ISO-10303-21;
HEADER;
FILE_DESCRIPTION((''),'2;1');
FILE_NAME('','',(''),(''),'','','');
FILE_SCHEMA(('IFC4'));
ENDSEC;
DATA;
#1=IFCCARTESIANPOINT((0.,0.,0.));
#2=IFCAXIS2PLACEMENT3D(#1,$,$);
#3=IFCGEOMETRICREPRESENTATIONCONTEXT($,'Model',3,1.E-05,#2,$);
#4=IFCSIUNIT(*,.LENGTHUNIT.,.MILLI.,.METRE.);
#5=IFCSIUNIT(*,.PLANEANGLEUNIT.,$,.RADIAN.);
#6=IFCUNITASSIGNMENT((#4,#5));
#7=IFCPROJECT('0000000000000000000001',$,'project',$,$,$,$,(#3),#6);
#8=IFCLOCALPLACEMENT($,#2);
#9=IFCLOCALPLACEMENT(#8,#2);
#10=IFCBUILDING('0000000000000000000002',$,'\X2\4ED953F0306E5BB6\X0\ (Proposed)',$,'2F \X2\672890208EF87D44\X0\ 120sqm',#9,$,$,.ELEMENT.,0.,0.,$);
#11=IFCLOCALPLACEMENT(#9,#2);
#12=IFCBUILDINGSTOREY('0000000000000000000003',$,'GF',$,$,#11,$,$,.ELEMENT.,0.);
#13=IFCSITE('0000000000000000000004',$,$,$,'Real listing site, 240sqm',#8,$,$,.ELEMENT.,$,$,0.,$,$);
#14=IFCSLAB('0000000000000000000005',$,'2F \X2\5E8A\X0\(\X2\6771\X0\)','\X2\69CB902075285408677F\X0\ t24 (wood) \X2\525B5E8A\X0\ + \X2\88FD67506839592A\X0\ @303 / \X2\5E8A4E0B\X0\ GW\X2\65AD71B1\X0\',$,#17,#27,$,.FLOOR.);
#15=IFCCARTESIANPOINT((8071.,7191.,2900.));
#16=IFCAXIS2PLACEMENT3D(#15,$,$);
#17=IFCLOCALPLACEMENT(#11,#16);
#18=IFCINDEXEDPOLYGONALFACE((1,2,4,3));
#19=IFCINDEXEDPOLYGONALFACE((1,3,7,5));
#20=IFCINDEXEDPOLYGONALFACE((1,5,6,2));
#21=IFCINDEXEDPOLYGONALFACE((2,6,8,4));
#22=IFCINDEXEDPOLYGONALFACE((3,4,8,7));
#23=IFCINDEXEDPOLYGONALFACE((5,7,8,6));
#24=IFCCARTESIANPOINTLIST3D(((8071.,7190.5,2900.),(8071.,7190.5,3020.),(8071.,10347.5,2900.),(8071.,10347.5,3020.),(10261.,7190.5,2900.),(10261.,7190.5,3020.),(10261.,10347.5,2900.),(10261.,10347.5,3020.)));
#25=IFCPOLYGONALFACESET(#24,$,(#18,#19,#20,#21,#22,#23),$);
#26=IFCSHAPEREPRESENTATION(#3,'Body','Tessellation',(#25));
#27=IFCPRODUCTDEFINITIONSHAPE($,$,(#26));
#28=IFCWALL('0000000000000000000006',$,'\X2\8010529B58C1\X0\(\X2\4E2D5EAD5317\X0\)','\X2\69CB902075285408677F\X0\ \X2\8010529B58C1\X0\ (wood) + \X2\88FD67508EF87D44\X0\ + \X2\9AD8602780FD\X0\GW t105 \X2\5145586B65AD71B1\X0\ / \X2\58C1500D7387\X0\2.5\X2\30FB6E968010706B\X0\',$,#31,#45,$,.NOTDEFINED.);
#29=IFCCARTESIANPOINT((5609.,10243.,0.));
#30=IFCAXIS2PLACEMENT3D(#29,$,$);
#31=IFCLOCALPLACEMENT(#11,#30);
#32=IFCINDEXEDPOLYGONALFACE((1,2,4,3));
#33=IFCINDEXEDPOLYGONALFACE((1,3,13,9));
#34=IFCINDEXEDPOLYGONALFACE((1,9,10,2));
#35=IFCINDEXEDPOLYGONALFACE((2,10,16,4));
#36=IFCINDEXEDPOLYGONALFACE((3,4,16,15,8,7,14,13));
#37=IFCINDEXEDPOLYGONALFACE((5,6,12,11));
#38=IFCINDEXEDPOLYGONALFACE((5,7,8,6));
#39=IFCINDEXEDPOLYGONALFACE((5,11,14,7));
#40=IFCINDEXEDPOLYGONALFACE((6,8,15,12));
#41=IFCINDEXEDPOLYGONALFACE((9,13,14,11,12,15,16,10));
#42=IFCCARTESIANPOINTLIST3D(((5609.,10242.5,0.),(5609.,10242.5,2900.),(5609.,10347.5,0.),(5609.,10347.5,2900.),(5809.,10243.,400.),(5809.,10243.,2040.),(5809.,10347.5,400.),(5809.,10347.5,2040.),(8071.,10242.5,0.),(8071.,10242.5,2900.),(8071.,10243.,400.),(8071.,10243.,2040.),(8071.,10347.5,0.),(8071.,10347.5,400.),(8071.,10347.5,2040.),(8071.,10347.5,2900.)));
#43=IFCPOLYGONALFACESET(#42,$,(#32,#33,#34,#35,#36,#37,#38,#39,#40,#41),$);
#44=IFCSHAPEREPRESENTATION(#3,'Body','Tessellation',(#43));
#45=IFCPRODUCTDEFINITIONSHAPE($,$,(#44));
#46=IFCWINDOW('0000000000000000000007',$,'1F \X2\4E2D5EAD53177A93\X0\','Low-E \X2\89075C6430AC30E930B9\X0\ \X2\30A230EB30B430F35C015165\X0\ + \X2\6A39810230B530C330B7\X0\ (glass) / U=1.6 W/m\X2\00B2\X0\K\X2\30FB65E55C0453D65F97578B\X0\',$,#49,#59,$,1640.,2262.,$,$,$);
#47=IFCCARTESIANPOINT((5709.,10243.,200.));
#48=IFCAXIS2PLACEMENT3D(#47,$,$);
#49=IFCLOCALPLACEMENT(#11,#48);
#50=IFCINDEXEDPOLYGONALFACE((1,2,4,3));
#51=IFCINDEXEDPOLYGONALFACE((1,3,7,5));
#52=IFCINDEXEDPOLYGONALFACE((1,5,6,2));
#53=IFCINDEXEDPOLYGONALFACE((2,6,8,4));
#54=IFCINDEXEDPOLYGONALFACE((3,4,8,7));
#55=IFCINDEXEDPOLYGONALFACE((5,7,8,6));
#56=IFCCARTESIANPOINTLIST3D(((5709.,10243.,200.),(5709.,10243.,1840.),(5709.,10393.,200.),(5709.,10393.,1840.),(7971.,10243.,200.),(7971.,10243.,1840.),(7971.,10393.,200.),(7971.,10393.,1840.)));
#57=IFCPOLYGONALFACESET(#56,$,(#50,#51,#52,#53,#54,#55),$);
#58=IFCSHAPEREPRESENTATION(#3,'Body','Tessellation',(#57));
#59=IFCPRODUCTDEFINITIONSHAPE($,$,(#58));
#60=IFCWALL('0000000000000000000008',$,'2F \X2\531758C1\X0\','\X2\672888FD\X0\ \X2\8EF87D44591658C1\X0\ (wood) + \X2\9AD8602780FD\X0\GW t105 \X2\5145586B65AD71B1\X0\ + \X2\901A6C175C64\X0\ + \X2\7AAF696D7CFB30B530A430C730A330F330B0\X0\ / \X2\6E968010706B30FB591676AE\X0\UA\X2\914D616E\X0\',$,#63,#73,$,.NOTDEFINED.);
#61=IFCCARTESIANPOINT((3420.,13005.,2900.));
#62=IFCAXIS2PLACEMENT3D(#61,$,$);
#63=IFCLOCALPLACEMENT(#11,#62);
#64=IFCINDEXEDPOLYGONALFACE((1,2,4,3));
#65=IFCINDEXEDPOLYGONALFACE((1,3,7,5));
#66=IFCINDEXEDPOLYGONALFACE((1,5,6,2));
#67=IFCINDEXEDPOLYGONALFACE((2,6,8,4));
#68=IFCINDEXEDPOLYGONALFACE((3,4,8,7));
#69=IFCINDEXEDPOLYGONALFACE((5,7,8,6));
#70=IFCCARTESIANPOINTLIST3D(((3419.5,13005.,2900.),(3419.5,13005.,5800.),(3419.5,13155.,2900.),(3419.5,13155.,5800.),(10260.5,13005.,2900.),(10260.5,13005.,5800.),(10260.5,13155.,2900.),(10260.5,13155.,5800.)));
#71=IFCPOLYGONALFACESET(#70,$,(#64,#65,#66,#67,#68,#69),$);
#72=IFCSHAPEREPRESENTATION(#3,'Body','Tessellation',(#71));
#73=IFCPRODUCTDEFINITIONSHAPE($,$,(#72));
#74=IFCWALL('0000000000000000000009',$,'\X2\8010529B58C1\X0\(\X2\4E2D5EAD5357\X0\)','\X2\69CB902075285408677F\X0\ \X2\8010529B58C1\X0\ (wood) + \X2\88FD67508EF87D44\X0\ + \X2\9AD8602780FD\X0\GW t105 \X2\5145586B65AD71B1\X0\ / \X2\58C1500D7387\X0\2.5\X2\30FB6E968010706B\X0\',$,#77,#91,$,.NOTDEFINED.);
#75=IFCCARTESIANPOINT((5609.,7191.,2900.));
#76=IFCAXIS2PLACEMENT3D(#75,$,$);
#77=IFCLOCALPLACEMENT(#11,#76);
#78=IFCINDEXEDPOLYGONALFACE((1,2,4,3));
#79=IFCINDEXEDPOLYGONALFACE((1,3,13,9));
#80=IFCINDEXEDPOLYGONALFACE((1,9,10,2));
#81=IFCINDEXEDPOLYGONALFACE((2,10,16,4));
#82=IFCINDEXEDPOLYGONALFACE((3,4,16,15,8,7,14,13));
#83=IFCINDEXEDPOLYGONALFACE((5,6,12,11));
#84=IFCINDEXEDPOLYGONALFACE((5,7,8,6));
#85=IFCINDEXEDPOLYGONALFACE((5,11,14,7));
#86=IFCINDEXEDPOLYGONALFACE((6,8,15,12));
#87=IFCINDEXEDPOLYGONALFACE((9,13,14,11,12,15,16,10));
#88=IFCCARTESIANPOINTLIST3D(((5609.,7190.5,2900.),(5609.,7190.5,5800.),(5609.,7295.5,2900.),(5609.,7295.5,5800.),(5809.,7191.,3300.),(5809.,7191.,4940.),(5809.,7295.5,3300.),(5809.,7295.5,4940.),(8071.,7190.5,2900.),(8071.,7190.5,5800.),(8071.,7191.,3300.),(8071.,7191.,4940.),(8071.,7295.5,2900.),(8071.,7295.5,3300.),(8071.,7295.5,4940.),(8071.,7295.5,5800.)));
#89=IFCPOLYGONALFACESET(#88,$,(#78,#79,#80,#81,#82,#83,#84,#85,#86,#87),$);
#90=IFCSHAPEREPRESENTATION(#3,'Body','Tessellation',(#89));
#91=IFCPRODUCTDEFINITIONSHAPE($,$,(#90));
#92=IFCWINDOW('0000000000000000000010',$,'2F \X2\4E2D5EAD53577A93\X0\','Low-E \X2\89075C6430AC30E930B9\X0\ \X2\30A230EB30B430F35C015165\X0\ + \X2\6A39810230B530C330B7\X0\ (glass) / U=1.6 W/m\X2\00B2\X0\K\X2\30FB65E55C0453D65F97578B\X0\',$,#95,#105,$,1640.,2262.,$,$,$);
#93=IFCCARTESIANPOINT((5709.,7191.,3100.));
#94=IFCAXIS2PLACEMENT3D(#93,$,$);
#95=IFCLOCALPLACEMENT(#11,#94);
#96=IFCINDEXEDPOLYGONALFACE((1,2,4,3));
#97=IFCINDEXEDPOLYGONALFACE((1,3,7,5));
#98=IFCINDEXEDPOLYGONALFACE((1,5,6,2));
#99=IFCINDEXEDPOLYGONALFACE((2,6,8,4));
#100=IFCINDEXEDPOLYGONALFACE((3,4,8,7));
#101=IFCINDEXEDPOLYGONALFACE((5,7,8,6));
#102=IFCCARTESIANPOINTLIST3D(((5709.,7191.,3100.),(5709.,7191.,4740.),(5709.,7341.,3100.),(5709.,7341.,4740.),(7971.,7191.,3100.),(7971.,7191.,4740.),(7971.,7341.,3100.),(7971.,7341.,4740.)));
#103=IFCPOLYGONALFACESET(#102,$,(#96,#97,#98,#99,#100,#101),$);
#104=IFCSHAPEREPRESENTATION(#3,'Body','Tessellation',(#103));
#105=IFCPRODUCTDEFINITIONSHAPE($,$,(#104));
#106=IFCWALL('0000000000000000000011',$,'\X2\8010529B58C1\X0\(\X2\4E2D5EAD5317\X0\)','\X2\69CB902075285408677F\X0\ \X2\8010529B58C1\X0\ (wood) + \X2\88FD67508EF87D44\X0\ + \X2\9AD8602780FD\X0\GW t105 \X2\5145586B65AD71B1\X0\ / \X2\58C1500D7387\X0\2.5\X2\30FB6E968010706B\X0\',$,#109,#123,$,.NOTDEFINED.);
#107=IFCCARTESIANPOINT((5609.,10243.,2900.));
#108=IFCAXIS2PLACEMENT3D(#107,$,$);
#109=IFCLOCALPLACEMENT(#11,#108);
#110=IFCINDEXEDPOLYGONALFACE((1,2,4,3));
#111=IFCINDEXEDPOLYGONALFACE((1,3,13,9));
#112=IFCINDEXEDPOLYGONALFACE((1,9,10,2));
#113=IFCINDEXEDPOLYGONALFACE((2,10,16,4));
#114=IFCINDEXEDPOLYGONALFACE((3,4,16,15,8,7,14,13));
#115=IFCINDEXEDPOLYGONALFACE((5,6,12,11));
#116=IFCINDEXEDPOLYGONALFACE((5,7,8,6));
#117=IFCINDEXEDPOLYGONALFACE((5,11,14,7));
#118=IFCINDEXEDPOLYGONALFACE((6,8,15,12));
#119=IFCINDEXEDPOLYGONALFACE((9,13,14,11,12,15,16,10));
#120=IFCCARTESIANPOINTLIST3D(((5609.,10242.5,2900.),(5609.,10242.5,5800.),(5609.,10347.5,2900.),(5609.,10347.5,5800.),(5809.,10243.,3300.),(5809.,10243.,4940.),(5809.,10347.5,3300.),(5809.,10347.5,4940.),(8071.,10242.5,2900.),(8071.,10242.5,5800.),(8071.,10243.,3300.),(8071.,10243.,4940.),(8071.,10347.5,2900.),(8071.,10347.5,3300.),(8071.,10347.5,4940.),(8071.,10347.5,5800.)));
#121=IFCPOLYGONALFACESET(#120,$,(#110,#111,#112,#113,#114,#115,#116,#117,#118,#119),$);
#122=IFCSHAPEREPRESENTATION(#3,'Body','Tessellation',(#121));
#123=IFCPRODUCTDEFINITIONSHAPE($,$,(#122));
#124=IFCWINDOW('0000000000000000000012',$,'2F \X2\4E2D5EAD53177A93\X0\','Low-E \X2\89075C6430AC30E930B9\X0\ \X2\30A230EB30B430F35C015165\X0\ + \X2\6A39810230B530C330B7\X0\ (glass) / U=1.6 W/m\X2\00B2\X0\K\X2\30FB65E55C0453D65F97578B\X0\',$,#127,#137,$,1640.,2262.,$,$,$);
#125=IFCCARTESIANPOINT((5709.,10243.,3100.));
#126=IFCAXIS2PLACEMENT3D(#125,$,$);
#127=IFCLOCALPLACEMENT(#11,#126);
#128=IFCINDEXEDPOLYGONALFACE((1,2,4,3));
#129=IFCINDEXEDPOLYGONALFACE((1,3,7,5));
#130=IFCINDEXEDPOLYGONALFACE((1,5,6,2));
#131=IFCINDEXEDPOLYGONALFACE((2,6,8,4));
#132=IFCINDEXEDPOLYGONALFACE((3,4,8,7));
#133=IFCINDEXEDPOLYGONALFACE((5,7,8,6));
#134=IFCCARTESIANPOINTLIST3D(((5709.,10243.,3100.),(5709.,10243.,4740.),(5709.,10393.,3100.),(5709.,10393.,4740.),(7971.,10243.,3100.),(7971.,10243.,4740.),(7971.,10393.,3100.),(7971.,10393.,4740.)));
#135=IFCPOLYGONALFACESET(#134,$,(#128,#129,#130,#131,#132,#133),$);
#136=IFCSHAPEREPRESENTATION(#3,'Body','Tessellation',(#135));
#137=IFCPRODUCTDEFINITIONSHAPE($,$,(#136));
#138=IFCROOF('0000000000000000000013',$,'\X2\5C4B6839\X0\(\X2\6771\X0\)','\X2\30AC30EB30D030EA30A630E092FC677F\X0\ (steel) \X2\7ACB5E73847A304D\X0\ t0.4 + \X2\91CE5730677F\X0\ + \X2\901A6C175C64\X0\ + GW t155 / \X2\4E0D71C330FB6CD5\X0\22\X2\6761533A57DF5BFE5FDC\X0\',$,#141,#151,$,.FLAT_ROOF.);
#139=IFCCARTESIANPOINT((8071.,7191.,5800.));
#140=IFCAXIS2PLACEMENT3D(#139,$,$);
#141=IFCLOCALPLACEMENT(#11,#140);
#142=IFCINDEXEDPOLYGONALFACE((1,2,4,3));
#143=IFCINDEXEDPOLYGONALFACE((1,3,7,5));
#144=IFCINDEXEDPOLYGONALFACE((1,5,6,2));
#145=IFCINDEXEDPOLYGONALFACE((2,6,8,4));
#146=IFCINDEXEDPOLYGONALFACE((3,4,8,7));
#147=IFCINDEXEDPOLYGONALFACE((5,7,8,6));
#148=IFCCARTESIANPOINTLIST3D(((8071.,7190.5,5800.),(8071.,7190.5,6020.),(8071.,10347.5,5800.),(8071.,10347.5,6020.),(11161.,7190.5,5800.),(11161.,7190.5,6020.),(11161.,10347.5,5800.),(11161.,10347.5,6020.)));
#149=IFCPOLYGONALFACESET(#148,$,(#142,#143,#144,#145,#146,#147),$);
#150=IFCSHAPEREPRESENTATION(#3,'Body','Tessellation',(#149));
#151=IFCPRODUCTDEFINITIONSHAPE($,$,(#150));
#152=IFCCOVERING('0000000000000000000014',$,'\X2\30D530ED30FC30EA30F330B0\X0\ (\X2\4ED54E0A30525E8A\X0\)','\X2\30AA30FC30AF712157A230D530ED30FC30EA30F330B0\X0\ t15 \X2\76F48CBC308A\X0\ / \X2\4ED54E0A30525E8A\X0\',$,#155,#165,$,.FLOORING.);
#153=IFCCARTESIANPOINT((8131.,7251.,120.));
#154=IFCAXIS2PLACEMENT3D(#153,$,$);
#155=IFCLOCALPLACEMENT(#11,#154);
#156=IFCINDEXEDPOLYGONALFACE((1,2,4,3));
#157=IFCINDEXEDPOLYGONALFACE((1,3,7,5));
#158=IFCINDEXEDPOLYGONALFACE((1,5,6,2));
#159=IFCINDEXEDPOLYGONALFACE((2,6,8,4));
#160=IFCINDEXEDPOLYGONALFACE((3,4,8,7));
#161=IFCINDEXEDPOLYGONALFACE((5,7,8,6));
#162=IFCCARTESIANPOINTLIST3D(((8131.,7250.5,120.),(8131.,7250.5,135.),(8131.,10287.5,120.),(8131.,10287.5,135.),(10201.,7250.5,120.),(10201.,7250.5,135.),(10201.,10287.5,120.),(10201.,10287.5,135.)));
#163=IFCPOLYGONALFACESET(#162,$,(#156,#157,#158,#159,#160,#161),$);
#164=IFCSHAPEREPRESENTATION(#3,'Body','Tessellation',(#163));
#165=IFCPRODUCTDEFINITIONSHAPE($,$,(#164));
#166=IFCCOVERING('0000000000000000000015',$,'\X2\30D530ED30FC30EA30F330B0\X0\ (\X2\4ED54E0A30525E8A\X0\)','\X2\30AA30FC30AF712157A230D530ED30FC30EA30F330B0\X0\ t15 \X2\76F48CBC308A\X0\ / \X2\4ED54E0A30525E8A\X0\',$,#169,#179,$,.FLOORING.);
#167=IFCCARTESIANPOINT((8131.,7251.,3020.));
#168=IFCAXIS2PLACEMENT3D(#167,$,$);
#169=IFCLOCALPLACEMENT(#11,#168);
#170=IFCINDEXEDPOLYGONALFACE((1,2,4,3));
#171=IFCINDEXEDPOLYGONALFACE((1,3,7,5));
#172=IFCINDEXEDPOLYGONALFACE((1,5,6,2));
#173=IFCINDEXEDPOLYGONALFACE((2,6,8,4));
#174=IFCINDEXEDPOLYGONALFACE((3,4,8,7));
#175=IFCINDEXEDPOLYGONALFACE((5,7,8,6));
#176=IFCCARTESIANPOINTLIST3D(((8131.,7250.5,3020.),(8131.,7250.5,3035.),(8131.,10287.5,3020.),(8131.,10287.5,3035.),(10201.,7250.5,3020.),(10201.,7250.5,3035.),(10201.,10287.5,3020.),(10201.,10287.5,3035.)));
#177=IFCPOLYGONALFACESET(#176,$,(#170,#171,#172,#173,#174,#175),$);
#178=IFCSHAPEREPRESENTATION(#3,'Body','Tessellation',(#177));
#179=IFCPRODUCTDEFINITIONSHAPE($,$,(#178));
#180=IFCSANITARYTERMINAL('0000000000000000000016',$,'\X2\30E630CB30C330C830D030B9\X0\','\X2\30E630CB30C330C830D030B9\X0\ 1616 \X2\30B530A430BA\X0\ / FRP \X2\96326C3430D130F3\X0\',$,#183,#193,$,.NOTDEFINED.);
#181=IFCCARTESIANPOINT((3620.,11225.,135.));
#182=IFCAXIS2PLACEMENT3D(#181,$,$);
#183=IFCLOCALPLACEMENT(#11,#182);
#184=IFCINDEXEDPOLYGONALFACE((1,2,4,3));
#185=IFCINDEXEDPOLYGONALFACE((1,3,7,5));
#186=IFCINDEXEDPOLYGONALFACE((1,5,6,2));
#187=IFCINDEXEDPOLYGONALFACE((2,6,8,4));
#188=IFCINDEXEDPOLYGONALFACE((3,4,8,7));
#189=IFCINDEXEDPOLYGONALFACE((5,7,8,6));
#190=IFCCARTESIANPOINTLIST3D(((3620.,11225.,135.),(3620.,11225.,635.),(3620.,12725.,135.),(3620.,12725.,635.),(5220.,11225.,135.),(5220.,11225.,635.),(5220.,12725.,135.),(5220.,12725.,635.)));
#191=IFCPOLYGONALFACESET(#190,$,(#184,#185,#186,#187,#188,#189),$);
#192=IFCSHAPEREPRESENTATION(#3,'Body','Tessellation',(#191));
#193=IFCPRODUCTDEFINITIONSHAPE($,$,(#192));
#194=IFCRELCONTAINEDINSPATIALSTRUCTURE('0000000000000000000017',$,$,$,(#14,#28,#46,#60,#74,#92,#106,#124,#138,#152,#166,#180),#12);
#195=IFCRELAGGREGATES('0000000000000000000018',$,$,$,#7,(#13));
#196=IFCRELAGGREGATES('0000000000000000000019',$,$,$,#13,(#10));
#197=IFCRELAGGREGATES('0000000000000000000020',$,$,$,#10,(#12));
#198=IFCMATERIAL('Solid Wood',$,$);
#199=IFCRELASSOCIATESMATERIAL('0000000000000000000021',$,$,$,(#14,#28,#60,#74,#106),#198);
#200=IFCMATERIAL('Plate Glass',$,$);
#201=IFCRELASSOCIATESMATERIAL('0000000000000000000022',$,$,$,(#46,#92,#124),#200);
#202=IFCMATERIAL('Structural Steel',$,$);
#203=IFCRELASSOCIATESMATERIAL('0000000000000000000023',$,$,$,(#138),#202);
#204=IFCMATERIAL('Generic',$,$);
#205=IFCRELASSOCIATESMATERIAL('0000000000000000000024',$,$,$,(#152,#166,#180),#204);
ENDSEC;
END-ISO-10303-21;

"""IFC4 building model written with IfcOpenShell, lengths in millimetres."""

from ifc_helpers import new_model, si_unit, frame, frame_2d, origin, place, context, project, spatial, rectangle, extrude, material, element, fill, save


model = new_model("IFC4")

# Units and contexts
model_context = context("Model", 3, precision=1e-05, world=origin())
ifc_project = project(units=[si_unit("LENGTHUNIT", "METRE", prefix="MILLI"), si_unit("PLANEANGLEUNIT", "RADIAN")], contexts=[model_context])

# Site, building, storey
site_placement = place(None, origin())
site = spatial("IfcSite", under=ifc_project, at=site_placement, ObjectType="Real listing site, 240sqm", CompositionType="ELEMENT", RefElevation=0.0)
building_placement = place(site_placement, origin())
building = spatial("IfcBuilding", under=site, at=building_placement, Name="仙台の家 (Proposed)", ObjectType="2F 木造軸組 120sqm", CompositionType="ELEMENT", ElevationOfRefHeight=0.0, ElevationOfTerrain=0.0)
storey_placement = place(building_placement, origin())
storey = spatial("IfcBuildingStorey", under=building, at=storey_placement, Name="GF", CompositionType="ELEMENT", Elevation=0.0)

# Slab
ifc_material_1 = material(Name="Solid Wood")
slab_1_placement = place(storey_placement, frame((8071.0, 7191.0, 2900.0)))
element("IfcSlab", 1, at=slab_1_placement, inside=storey, material=ifc_material_1, Name="2F 床(東)", Description="構造用合板 t24 (wood) 剛床 + 製材根太 @303 / 床下 GW断熱", PredefinedType="FLOOR", context=model_context, shape_type="SweptSolid", body=[
    extrude(rectangle(XDim=2190.0, YDim=3157.0, at=frame_2d((1095.0, 1578.0))), frame((8071.0, 7191.0, 2900.0)), (0.0, 0.0, 1.0), 120.0),
])

# Wall, opening, window
wall_1_placement = place(storey_placement, frame((5609.0, 10243.0, 0.0)))
wall_1 = element("IfcWall", 2, at=wall_1_placement, inside=storey, material=ifc_material_1, Name="耐力壁(中庭北)", Description="構造用合板 耐力壁 (wood) + 製材軸組 + 高性能GW t105 充填断熱 / 壁倍率2.5・準耐火", PredefinedType="NOTDEFINED", context=model_context, shape_type="SweptSolid", body=[
    extrude(rectangle(XDim=2462.0, YDim=105.0, at=frame_2d((1231.0, 52.0))), frame((5609.0, 10243.0, 0.0)), (0.0, 0.0, 1.0), 2900.0),
])
opening_1_placement = place(storey_placement, frame((5709.0, 10243.0, 200.0)))
opening_1 = element("IfcOpeningElement", 3, at=opening_1_placement, cuts=wall_1, PredefinedType="NOTDEFINED", context=model_context, shape_type="SweptSolid", body=[
    extrude(rectangle(XDim=2262.0, YDim=150.0, at=frame_2d((1131.0, 75.0))), frame((5709.0, 10243.0, 200.0)), (0.0, 0.0, 1.0), 1640.0),
])
ifc_material_2 = material(Name="Plate Glass")
window_1_placement = place(storey_placement, frame((5709.0, 10243.0, 200.0)))
window_1 = element("IfcWindow", 4, at=window_1_placement, inside=storey, material=ifc_material_2, Name="1F 中庭北窓", Description="Low-E 複層ガラス アルゴン封入 + 樹脂サッシ (glass) / U=1.6 W/m²K・日射取得型", OverallHeight=1640.0, OverallWidth=2262.0, context=model_context, shape_type="SweptSolid", body=[
    extrude(rectangle(XDim=2262.0, YDim=150.0, at=frame_2d((1131.0, 75.0))), frame((5709.0, 10243.0, 200.0)), (0.0, 0.0, 1.0), 1640.0),
])
fill(opening_1, window_1)

# Wall
wall_2_placement = place(storey_placement, frame((3420.0, 13005.0, 2900.0)))
element("IfcWall", 5, at=wall_2_placement, inside=storey, material=ifc_material_1, Name="2F 北壁", Description="木製 軸組外壁 (wood) + 高性能GW t105 充填断熱 + 通気層 + 窯業系サイディング / 準耐火・外皮UA配慮", PredefinedType="NOTDEFINED", context=model_context, shape_type="SweptSolid", body=[
    extrude(rectangle(XDim=6841.0, YDim=150.0, at=frame_2d((3420.0, 75.0))), frame((3420.0, 13005.0, 2900.0)), (0.0, 0.0, 1.0), 2900.0),
])

# Walls, openings, windows
wall_3_placement = place(storey_placement, frame((5609.0, 7191.0, 2900.0)))
wall_3 = element("IfcWall", 6, at=wall_3_placement, inside=storey, material=ifc_material_1, Name="耐力壁(中庭南)", Description="構造用合板 耐力壁 (wood) + 製材軸組 + 高性能GW t105 充填断熱 / 壁倍率2.5・準耐火", PredefinedType="NOTDEFINED", context=model_context, shape_type="SweptSolid", body=[
    extrude(rectangle(XDim=2462.0, YDim=105.0, at=frame_2d((1231.0, 52.0))), frame((5609.0, 7191.0, 2900.0)), (0.0, 0.0, 1.0), 2900.0),
])
opening_2_placement = place(storey_placement, frame((5709.0, 7191.0, 3100.0)))
opening_2 = element("IfcOpeningElement", 7, at=opening_2_placement, cuts=wall_3, PredefinedType="NOTDEFINED", context=model_context, shape_type="SweptSolid", body=[
    extrude(rectangle(XDim=2262.0, YDim=150.0, at=frame_2d((1131.0, 75.0))), frame((5709.0, 7191.0, 3100.0)), (0.0, 0.0, 1.0), 1640.0),
])
window_2_placement = place(storey_placement, frame((5709.0, 7191.0, 3100.0)))
window_2 = element("IfcWindow", 8, at=window_2_placement, inside=storey, material=ifc_material_2, Name="2F 中庭南窓", Description="Low-E 複層ガラス アルゴン封入 + 樹脂サッシ (glass) / U=1.6 W/m²K・日射取得型", OverallHeight=1640.0, OverallWidth=2262.0, context=model_context, shape_type="SweptSolid", body=[
    extrude(rectangle(XDim=2262.0, YDim=150.0, at=frame_2d((1131.0, 75.0))), frame((5709.0, 7191.0, 3100.0)), (0.0, 0.0, 1.0), 1640.0),
])
fill(opening_2, window_2)
wall_4_placement = place(storey_placement, frame((5609.0, 10243.0, 2900.0)))
wall_4 = element("IfcWall", 9, at=wall_4_placement, inside=storey, material=ifc_material_1, Name="耐力壁(中庭北)", Description="構造用合板 耐力壁 (wood) + 製材軸組 + 高性能GW t105 充填断熱 / 壁倍率2.5・準耐火", PredefinedType="NOTDEFINED", context=model_context, shape_type="SweptSolid", body=[
    extrude(rectangle(XDim=2462.0, YDim=105.0, at=frame_2d((1231.0, 52.0))), frame((5609.0, 10243.0, 2900.0)), (0.0, 0.0, 1.0), 2900.0),
])
opening_3_placement = place(storey_placement, frame((5709.0, 10243.0, 3100.0)))
opening_3 = element("IfcOpeningElement", 10, at=opening_3_placement, cuts=wall_4, PredefinedType="NOTDEFINED", context=model_context, shape_type="SweptSolid", body=[
    extrude(rectangle(XDim=2262.0, YDim=150.0, at=frame_2d((1131.0, 75.0))), frame((5709.0, 10243.0, 3100.0)), (0.0, 0.0, 1.0), 1640.0),
])
window_3_placement = place(storey_placement, frame((5709.0, 10243.0, 3100.0)))
window_3 = element("IfcWindow", 11, at=window_3_placement, inside=storey, material=ifc_material_2, Name="2F 中庭北窓", Description="Low-E 複層ガラス アルゴン封入 + 樹脂サッシ (glass) / U=1.6 W/m²K・日射取得型", OverallHeight=1640.0, OverallWidth=2262.0, context=model_context, shape_type="SweptSolid", body=[
    extrude(rectangle(XDim=2262.0, YDim=150.0, at=frame_2d((1131.0, 75.0))), frame((5709.0, 10243.0, 3100.0)), (0.0, 0.0, 1.0), 1640.0),
])
fill(opening_3, window_3)

# Roof
ifc_material_3 = material(Name="Structural Steel")
roof_1_placement = place(storey_placement, frame((8071.0, 7191.0, 5800.0)))
element("IfcRoof", 12, at=roof_1_placement, inside=storey, material=ifc_material_3, Name="屋根(東)", Description="ガルバリウム鋼板 (steel) 立平葺き t0.4 + 野地板 + 通気層 + GW t155 / 不燃・法22条区域対応", PredefinedType="FLAT_ROOF", context=model_context, shape_type="SweptSolid", body=[
    extrude(rectangle(XDim=3090.0, YDim=3157.0, at=frame_2d((1545.0, 1578.0))), frame((8071.0, 7191.0, 5800.0)), (0.0, 0.0, 1.0), 220.0),
])

# Coverings
ifc_material_4 = material(Name="Generic")
covering_1_placement = place(storey_placement, frame((8131.0, 7251.0, 120.0)))
element("IfcCovering", 13, at=covering_1_placement, inside=storey, material=ifc_material_4, Name="フローリング (仕上げ床)", Description="オーク無垢フローリング t15 直貼り / 仕上げ床", PredefinedType="FLOORING", context=model_context, shape_type="SweptSolid", body=[
    extrude(rectangle(XDim=2070.0, YDim=3037.0, at=frame_2d((1035.0, 1518.0))), frame((8131.0, 7251.0, 120.0)), (0.0, 0.0, 1.0), 15.0),
])
covering_2_placement = place(storey_placement, frame((8131.0, 7251.0, 3020.0)))
element("IfcCovering", 14, at=covering_2_placement, inside=storey, material=ifc_material_4, Name="フローリング (仕上げ床)", Description="オーク無垢フローリング t15 直貼り / 仕上げ床", PredefinedType="FLOORING", context=model_context, shape_type="SweptSolid", body=[
    extrude(rectangle(XDim=2070.0, YDim=3037.0, at=frame_2d((1035.0, 1518.0))), frame((8131.0, 7251.0, 3020.0)), (0.0, 0.0, 1.0), 15.0),
])

# Sanitary terminal
sanitary_terminal_1_placement = place(storey_placement, frame((3620.0, 11225.0, 135.0)))
element("IfcSanitaryTerminal", 15, at=sanitary_terminal_1_placement, inside=storey, material=ifc_material_4, Name="ユニットバス", Description="ユニットバス 1616 サイズ / FRP 防水パン", PredefinedType="NOTDEFINED", context=model_context, shape_type="SweptSolid", body=[
    extrude(rectangle(XDim=1600.0, YDim=1500.0, at=frame_2d((800.0, 750.0))), frame((3620.0, 11225.0, 135.0)), (0.0, 0.0, 1.0), 500.0),
])

save(model, "model.ifc")
